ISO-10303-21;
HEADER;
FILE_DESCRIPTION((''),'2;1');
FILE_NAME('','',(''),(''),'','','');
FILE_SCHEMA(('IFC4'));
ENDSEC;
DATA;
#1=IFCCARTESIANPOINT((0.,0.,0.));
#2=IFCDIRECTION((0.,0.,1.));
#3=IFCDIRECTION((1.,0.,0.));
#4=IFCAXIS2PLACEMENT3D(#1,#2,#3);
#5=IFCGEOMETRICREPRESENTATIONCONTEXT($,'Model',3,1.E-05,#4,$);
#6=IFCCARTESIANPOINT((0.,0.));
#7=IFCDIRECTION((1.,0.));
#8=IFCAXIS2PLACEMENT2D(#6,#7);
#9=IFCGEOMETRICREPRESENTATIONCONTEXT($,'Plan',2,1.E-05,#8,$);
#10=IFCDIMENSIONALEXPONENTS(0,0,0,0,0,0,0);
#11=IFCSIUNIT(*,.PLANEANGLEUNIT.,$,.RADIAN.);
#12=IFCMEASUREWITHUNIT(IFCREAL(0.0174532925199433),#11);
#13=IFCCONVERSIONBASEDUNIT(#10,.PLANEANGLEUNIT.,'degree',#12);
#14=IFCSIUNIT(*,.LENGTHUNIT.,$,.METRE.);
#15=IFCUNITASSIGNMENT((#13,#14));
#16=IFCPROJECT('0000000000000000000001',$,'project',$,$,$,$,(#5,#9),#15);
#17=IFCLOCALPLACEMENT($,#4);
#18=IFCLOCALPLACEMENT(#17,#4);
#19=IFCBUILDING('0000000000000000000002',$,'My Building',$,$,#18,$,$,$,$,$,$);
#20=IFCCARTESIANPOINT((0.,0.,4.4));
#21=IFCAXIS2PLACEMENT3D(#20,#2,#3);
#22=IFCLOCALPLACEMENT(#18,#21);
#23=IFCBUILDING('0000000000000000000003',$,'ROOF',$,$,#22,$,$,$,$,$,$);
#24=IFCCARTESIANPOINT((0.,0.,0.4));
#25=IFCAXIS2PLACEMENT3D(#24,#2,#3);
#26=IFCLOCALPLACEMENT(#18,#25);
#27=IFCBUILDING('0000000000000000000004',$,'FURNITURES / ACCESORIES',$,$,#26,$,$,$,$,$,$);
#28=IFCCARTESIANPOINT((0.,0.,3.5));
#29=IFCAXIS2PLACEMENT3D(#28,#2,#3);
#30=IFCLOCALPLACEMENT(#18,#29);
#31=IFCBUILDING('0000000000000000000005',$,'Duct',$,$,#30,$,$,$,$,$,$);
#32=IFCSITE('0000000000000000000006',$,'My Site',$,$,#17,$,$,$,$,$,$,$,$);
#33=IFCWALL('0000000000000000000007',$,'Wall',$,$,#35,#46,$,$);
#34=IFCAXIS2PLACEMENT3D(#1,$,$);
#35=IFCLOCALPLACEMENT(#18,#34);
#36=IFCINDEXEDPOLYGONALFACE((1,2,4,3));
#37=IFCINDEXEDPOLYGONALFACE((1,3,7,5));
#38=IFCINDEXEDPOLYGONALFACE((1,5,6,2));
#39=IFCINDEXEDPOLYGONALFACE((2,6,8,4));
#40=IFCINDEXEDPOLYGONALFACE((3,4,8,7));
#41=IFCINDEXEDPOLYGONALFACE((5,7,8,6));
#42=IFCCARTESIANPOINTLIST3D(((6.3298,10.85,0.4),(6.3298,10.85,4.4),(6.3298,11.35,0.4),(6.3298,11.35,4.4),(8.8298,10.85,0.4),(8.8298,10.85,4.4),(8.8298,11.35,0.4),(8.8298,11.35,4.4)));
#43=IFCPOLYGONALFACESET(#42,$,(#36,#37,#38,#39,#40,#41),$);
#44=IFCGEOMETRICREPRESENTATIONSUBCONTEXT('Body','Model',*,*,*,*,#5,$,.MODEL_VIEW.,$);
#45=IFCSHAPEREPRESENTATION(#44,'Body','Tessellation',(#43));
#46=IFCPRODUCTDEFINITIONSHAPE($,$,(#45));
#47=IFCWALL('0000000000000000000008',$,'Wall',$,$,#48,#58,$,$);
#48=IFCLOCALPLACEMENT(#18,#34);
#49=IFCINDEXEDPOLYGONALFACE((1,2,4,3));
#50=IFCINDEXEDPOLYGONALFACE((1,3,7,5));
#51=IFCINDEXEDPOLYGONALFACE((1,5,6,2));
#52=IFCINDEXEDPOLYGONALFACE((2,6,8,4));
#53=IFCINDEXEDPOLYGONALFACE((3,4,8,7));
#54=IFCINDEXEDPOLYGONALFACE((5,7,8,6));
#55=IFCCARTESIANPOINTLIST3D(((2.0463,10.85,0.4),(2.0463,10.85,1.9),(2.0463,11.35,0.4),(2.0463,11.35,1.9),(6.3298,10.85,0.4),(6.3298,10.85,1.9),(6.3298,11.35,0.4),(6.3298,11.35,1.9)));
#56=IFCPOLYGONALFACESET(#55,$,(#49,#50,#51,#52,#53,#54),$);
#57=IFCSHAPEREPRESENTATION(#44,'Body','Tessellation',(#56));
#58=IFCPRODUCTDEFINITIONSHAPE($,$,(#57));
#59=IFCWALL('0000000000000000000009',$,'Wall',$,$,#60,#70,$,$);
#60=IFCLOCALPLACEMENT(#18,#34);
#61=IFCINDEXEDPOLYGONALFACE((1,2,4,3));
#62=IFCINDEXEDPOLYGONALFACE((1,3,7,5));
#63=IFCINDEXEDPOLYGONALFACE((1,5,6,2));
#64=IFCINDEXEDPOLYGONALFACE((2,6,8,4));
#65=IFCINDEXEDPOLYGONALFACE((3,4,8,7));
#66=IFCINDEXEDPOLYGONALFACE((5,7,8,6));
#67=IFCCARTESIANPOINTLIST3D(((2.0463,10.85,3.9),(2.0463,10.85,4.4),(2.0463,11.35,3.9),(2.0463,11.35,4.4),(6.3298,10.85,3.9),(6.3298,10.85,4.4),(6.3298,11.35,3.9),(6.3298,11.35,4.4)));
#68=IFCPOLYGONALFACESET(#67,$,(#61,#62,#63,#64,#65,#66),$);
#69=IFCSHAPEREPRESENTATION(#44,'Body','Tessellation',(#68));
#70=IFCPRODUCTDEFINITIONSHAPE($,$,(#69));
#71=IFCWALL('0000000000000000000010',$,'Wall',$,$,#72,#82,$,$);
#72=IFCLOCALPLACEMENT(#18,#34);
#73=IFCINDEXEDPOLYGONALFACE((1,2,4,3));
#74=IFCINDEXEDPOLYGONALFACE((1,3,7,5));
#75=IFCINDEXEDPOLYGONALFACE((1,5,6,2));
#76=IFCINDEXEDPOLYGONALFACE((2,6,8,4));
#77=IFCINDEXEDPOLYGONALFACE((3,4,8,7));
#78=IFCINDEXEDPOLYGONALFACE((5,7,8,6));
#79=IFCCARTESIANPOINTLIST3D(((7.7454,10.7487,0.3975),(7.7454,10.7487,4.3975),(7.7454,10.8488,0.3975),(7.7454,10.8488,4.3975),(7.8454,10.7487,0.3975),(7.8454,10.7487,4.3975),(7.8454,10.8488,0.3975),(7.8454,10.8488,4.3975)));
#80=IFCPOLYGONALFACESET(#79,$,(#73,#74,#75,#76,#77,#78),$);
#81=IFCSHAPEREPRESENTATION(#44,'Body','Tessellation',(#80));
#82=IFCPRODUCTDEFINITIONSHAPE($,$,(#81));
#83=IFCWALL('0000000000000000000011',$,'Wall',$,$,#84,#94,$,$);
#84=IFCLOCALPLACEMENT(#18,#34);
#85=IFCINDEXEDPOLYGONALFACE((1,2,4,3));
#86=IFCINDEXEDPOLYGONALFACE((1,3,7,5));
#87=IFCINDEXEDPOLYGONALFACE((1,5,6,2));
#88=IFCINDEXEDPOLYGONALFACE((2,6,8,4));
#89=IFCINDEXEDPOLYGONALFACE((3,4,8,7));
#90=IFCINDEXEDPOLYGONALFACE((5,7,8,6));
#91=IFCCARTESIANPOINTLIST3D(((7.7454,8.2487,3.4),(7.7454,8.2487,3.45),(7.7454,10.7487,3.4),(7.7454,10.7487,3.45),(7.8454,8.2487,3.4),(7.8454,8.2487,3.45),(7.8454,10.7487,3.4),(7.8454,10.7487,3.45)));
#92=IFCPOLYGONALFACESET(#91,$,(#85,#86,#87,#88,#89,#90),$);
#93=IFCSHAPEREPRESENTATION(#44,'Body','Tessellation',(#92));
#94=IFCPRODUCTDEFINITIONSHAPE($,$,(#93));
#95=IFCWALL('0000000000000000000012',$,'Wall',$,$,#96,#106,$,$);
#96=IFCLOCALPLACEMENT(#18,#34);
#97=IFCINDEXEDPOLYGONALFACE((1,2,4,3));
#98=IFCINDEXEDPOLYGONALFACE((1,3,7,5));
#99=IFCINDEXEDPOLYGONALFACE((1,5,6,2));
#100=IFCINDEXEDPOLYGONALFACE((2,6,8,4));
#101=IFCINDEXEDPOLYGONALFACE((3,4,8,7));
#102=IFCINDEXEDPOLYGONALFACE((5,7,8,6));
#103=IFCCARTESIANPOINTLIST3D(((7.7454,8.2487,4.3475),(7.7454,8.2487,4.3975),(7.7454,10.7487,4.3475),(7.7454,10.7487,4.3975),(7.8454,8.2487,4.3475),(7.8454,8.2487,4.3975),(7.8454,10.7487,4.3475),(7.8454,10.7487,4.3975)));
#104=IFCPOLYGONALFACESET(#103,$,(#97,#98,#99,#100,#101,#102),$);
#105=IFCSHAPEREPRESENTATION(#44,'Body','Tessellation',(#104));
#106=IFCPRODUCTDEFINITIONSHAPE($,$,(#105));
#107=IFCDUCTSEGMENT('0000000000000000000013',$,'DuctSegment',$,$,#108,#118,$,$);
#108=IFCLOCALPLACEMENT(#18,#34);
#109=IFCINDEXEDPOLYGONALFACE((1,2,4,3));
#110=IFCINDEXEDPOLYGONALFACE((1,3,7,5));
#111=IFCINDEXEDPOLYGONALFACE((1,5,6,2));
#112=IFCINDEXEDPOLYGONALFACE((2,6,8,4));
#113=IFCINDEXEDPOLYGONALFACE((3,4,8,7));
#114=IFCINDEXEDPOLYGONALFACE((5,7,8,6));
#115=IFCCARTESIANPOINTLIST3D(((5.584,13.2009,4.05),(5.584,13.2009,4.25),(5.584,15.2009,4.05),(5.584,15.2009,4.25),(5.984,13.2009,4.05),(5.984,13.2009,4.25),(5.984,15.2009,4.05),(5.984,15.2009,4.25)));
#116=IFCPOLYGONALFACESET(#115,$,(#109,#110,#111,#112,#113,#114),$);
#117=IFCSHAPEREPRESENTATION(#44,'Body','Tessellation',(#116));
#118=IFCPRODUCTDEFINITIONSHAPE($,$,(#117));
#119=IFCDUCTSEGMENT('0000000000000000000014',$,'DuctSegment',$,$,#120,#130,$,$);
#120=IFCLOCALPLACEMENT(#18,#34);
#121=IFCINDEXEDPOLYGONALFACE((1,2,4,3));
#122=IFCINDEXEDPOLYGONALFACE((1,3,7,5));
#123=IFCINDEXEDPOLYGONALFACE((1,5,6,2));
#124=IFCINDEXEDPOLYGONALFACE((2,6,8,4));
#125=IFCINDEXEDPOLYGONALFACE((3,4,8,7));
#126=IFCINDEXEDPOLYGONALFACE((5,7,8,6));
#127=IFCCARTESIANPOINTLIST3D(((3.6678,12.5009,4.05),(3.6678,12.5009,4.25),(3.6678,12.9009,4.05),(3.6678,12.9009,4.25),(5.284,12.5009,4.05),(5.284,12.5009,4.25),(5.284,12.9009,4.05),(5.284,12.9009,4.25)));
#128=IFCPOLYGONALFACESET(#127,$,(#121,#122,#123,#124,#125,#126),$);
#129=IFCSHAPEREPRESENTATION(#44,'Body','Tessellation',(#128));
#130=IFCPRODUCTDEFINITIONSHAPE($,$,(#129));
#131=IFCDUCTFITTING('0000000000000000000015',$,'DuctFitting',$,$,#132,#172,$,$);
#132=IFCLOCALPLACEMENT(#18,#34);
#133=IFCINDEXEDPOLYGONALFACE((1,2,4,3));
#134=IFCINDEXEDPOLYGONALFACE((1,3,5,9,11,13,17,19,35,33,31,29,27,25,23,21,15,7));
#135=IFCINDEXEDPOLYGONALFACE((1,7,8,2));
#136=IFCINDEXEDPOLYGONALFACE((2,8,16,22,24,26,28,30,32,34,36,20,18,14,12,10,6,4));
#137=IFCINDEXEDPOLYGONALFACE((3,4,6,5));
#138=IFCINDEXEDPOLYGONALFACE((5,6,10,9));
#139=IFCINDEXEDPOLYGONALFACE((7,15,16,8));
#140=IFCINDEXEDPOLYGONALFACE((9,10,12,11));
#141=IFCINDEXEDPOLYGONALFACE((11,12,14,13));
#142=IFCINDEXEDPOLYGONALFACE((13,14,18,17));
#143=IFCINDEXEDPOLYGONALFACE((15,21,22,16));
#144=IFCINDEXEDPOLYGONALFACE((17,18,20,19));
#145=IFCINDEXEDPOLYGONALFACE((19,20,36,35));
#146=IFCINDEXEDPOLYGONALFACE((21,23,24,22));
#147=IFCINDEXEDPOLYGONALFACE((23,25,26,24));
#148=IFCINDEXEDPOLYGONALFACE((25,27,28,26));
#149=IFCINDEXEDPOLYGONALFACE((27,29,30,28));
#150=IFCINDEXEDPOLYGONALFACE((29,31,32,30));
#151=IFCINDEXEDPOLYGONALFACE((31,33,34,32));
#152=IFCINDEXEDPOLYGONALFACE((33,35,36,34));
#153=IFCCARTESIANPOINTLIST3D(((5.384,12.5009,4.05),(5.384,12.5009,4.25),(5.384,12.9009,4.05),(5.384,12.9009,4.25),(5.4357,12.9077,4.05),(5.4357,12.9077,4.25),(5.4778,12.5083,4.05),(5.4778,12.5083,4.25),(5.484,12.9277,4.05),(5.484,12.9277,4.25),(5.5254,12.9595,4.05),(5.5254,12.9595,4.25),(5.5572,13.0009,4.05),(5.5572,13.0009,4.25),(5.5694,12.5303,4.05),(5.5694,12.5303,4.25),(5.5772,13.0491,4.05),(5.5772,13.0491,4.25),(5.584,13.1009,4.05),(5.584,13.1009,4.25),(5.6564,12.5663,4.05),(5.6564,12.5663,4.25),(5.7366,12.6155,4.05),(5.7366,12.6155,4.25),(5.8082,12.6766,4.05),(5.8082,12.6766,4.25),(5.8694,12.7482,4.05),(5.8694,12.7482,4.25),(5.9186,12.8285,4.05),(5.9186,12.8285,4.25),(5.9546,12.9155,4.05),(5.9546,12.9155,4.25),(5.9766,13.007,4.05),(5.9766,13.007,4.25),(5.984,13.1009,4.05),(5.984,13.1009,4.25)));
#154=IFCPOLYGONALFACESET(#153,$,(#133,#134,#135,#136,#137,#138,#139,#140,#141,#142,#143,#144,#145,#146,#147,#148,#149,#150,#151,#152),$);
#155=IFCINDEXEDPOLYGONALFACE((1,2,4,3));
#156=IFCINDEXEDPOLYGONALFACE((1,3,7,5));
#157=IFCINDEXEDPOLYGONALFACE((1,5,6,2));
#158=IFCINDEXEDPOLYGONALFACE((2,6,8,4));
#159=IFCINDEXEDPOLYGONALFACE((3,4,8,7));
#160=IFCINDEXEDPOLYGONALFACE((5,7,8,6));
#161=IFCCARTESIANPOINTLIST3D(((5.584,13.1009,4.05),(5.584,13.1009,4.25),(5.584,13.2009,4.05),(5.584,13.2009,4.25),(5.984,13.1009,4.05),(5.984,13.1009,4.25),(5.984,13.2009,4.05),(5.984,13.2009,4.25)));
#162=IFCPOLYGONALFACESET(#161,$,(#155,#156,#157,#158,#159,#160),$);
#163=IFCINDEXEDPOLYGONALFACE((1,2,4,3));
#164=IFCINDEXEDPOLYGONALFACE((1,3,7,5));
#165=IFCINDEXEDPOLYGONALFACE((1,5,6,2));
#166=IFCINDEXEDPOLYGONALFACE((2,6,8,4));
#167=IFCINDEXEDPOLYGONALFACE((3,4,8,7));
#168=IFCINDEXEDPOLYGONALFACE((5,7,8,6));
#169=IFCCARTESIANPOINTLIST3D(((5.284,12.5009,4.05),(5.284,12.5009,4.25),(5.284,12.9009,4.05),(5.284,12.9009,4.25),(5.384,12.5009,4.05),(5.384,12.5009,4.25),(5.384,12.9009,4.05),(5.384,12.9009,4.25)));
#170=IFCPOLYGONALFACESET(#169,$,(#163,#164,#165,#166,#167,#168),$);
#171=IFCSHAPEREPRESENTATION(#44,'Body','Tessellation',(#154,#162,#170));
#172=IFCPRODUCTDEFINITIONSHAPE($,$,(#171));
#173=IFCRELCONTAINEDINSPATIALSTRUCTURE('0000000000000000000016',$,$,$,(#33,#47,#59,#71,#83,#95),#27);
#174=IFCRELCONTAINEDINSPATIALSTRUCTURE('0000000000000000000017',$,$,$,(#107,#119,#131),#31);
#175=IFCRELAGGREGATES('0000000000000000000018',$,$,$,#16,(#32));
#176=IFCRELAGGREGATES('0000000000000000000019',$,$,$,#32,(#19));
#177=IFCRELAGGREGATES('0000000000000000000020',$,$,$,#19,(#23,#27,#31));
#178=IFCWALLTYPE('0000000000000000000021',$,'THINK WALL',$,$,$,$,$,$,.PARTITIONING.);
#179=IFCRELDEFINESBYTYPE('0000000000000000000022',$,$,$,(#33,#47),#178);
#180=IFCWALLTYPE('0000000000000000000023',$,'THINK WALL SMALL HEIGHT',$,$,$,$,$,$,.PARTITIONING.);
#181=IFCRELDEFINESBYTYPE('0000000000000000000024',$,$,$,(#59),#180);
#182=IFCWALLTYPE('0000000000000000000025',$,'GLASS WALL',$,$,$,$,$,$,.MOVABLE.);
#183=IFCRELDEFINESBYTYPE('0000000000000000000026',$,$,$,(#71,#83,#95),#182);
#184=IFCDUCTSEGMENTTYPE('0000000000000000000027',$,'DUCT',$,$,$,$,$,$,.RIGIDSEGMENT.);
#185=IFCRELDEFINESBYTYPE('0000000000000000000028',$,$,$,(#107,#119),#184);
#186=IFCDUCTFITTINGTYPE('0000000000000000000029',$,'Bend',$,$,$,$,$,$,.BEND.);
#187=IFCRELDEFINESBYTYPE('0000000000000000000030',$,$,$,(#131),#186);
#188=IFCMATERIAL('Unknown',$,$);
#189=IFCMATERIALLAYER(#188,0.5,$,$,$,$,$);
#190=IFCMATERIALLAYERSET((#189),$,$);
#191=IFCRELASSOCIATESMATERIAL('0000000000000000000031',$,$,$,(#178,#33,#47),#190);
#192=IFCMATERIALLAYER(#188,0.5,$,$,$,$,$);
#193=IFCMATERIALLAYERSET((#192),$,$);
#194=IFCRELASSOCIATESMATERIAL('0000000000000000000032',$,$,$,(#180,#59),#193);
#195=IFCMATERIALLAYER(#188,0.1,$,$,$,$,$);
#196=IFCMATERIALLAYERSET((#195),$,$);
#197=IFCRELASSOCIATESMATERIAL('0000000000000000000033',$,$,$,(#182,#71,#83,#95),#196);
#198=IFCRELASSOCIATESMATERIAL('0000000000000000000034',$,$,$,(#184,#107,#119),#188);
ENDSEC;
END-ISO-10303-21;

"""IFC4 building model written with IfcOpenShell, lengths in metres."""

from ifc_helpers import new_model, entity, si_unit, converted_unit, frame, origin_with_axes, origin_2d_with_axis, place, context, subcontext, project, spatial, line, arc, indexed_curve, rectangle, outline, extrude, source, transform, mapped, material, layer, layer_set, layer_usage, material_profile, profile_set, profile_usage, type_object, type_shapes, element, save


model = new_model("IFC4")

# Units and contexts
model_context = context("Model", 3, precision=1e-05, world=origin_with_axes())
plan_context = context("Plan", 2, precision=1e-05, world=origin_2d_with_axis())
body_context_1 = subcontext(model_context, "Body", "Model", "MODEL_VIEW")
ifc_project = project(units=[converted_unit("PLANEANGLEUNIT", "degree", entity("IfcReal", 0.0174532925199433), si_unit("PLANEANGLEUNIT", "RADIAN"), dimensions=[0, 0, 0, 0, 0, 0, 0]), si_unit("LENGTHUNIT", "METRE")], contexts=[model_context, plan_context])

# Site, building
site_placement = place(None, origin_with_axes())
site = spatial("IfcSite", under=ifc_project, at=site_placement, Name="My Site")
building_1_placement = place(site_placement, origin_with_axes())
building_1 = spatial("IfcBuilding", under=site, at=building_1_placement, Name="My Building")

# Shared definitions
ifc_material = material(Name="Unknown")

# Shared definitions
building_2_placement = place(building_1_placement, frame((0.0, 0.0, 4.4), z_axis=(0.0, 0.0, 1.0), x_axis=(1.0, 0.0, 0.0)))
building_2 = spatial("IfcBuilding", under=building_1, at=building_2_placement, Name="ROOF")

# Shared definitions
building_3_placement = place(building_1_placement, frame((0.0, 0.0, 0.4), z_axis=(0.0, 0.0, 1.0), x_axis=(1.0, 0.0, 0.0)))
building_3 = spatial("IfcBuilding", under=building_1, at=building_3_placement, Name="FURNITURES / ACCESORIES")

# Walls
ifc_layer_1 = layer(ifc_material, 0.5)
ifc_layer_set_1 = layer_set([ifc_layer_1])
ifc_layer_usage_1 = layer_usage(ifc_layer_set_1, "AXIS2", "POSITIVE", 0.0)
wall_type_1 = type_object("IfcWallType", Name="THINK WALL", PredefinedType="PARTITIONING", material=ifc_layer_set_1)
wall_1_placement = place(building_3_placement, frame((8.8298, 11.35, 0.0), z_axis=(0.0, 0.0, 1.0), x_axis=(-1.0, 0.0, 0.0)))
element("IfcWall", 1, at=wall_1_placement, inside=building_3, type_object=wall_type_1, material=ifc_layer_usage_1, Name="Wall", context=body_context_1, shape_type="SweptSolid", body=[
    extrude(outline(indexed_curve([(0.0, 0.0), (0.0, 0.5), (2.5, 0.5), (2.5, 0.0)], segments=[line(1, 2, 3, 4, 1)])), origin_with_axes(), (0.0, 0.0, 1.0), 4.0),
])
ifc_layer_usage_2 = layer_usage(ifc_layer_set_1, "AXIS2", "POSITIVE", 0.0)
wall_2_placement = place(building_3_placement, frame((6.3298, 11.35, 0.0), z_axis=(0.0, 0.0, 1.0), x_axis=(-1.0, 0.0, 0.0)))
element("IfcWall", 2, at=wall_2_placement, inside=building_3, type_object=wall_type_1, material=ifc_layer_usage_2, Name="Wall", context=body_context_1, shape_type="SweptSolid", body=[
    extrude(outline(indexed_curve([(0.0, 0.0), (0.0, 0.5), (4.2835, 0.5), (4.2835, 0.0)], segments=[line(1, 2, 3, 4, 1)])), origin_with_axes(), (0.0, 0.0, 1.0), 1.5),
])
ifc_layer_2 = layer(ifc_material, 0.5)
ifc_layer_set_2 = layer_set([ifc_layer_2])
ifc_layer_usage_3 = layer_usage(ifc_layer_set_2, "AXIS2", "POSITIVE", 0.0)
wall_type_2 = type_object("IfcWallType", Name="THINK WALL SMALL HEIGHT", PredefinedType="PARTITIONING", material=ifc_layer_set_2)
wall_3_placement = place(building_3_placement, frame((6.3298, 11.35, 3.5), z_axis=(0.0, 0.0, 1.0), x_axis=(-1.0, 0.0, 0.0)))
element("IfcWall", 3, at=wall_3_placement, inside=building_3, type_object=wall_type_2, material=ifc_layer_usage_3, Name="Wall", context=body_context_1, shape_type="SweptSolid", body=[
    extrude(outline(indexed_curve([(0.0, 0.0), (0.0, 0.5), (4.2835, 0.5), (4.2835, 0.0)], segments=[line(1, 2, 3, 4, 1)])), origin_with_axes(), (0.0, 0.0, 1.0), 0.5),
])
ifc_layer_3 = layer(ifc_material, 0.1)
ifc_layer_set_3 = layer_set([ifc_layer_3])
ifc_layer_usage_4 = layer_usage(ifc_layer_set_3, "AXIS2", "POSITIVE", 0.0)
wall_type_3 = type_object("IfcWallType", Name="GLASS WALL", PredefinedType="MOVABLE", material=ifc_layer_set_3)
wall_4_placement = place(building_3_placement, frame((7.7454, 10.8488, -0.0025), z_axis=(0.0, 0.0, 1.0), x_axis=(0.0, -1.0, 0.0)))
element("IfcWall", 4, at=wall_4_placement, inside=building_3, type_object=wall_type_3, material=ifc_layer_usage_4, Name="Wall", context=body_context_1, shape_type="SweptSolid", body=[
    extrude(outline(indexed_curve([(0.0, 0.0), (0.0, 0.1), (0.1, 0.1), (0.1, 0.0)], segments=[line(1, 2, 3, 4, 1)])), origin_with_axes(), (0.0, 0.0, 1.0), 4.0),
])
ifc_layer_usage_5 = layer_usage(ifc_layer_set_3, "AXIS2", "POSITIVE", 0.0)
wall_5_placement = place(building_3_placement, frame((7.7454, 10.7487, 3.0), z_axis=(0.0, 0.0, 1.0), x_axis=(0.0, -1.0, 0.0)))
element("IfcWall", 5, at=wall_5_placement, inside=building_3, type_object=wall_type_3, material=ifc_layer_usage_5, Name="Wall", context=body_context_1, shape_type="SweptSolid", body=[
    extrude(outline(indexed_curve([(0.0, 0.0), (0.0, 0.1), (2.5, 0.1), (2.5, 0.0)], segments=[line(1, 2, 3, 4, 1)])), origin_with_axes(), (0.0, 0.0, 1.0), 0.05),
])
ifc_layer_usage_6 = layer_usage(ifc_layer_set_3, "AXIS2", "POSITIVE", 0.0)
wall_6_placement = place(building_3_placement, frame((7.7454, 10.7487, 3.9475), z_axis=(0.0, 0.0, 1.0), x_axis=(0.0, -1.0, 0.0)))
element("IfcWall", 6, at=wall_6_placement, inside=building_3, type_object=wall_type_3, material=ifc_layer_usage_6, Name="Wall", context=body_context_1, shape_type="SweptSolid", body=[
    extrude(outline(indexed_curve([(0.0, 0.0), (0.0, 0.1), (2.5, 0.1), (2.5, 0.0)], segments=[line(1, 2, 3, 4, 1)])), origin_with_axes(), (0.0, 0.0, 1.0), 0.05),
])

# Shared definitions
building_4_placement = place(building_1_placement, frame((0.0, 0.0, 3.5), z_axis=(0.0, 0.0, 1.0), x_axis=(1.0, 0.0, 0.0)))
building_4 = spatial("IfcBuilding", under=building_1, at=building_4_placement, Name="Duct")

# Duct segments
ifc_material_profile = material_profile(ifc_material, rectangle(XDim=0.4, YDim=0.2))
ifc_profile_set = profile_set([ifc_material_profile])
ifc_profile_usage_1 = profile_usage(ifc_profile_set, cardinal=5)
duct_segment_type = type_object("IfcDuctSegmentType", Name="DUCT", PredefinedType="RIGIDSEGMENT", material=ifc_profile_set)
duct_segment_1_placement = place(building_4_placement, frame((5.784, 15.2009, 0.65), z_axis=(0.0, -1.0, 0.0), x_axis=(1.0, 0.0, 0.0)))
element("IfcDuctSegment", 7, at=duct_segment_1_placement, inside=building_4, type_object=duct_segment_type, material=ifc_profile_usage_1, Name="DuctSegment", context=body_context_1, shape_type="SweptSolid", body=[
    extrude(rectangle(XDim=0.4, YDim=0.2), origin_with_axes(), (0.0, 0.0, 1.0), 2.0),
])
ifc_profile_usage_2 = profile_usage(ifc_profile_set, cardinal=5)
duct_segment_2_placement = place(building_4_placement, frame((5.284, 12.7009, 0.65), z_axis=(-1.0, 0.0, 0.0), x_axis=(0.0, -1.0, 0.0)))
element("IfcDuctSegment", 8, at=duct_segment_2_placement, inside=building_4, type_object=duct_segment_type, material=ifc_profile_usage_2, Name="DuctSegment", context=body_context_1, shape_type="SweptSolid", body=[
    extrude(rectangle(XDim=0.4, YDim=0.2), origin_with_axes(), (0.0, 0.0, 1.0), 1.6162),
])

# Duct fitting
duct_fitting_type = type_object("IfcDuctFittingType", Name="Bend", PredefinedType="BEND")
shared_shape_1 = source(origin_with_axes(), body_context_1, "Body", "SweptSolid", [
    extrude(outline(indexed_curve([(0.2, 0.0), (0.2586, 0.1414), (0.4, 0.2), (0.4, 0.6), (-0.0243, 0.4243), (-0.2, 0.0)], segments=[arc(1, 2, 3), line(3, 4), arc(4, 5, 6), line(6, 1)])), frame((0.0, -0.1, 0.1), z_axis=(0.0, -1.0, 0.0), x_axis=(1.0, 0.0, 0.0)), (0.0, 0.0, -1.0), 0.2),
    extrude(rectangle(XDim=0.4, YDim=0.2), origin_with_axes(), (0.0, 0.0, 1.0), 0.1),
    extrude(rectangle(XDim=0.4, YDim=0.2), frame((0.4, 0.0, 0.5), z_axis=(1.0, 0.0, 0.0), x_axis=(0.0, 0.0, 1.0)), (0.0, 0.0, 1.0), 0.1),
])
type_shapes(duct_fitting_type, [shared_shape_1])
duct_fitting_placement = place(building_4_placement, frame((5.784, 13.2009, 0.65), z_axis=(0.0, -1.0, 0.0), x_axis=(-1.0, 0.0, 0.0)))
element("IfcDuctFitting", 9, at=duct_fitting_placement, inside=building_4, type_object=duct_fitting_type, Name="DuctFitting", context=body_context_1, shape_type="MappedRepresentation", body=[
    mapped(shared_shape_1, transform((0.0, 0.0, 0.0), x_axis=(1.0, 0.0, 0.0), y_axis=(0.0, 1.0, 0.0), z_axis=(0.0, 0.0, 1.0), scale=1.0)),
])

save(model, "model.ifc")
